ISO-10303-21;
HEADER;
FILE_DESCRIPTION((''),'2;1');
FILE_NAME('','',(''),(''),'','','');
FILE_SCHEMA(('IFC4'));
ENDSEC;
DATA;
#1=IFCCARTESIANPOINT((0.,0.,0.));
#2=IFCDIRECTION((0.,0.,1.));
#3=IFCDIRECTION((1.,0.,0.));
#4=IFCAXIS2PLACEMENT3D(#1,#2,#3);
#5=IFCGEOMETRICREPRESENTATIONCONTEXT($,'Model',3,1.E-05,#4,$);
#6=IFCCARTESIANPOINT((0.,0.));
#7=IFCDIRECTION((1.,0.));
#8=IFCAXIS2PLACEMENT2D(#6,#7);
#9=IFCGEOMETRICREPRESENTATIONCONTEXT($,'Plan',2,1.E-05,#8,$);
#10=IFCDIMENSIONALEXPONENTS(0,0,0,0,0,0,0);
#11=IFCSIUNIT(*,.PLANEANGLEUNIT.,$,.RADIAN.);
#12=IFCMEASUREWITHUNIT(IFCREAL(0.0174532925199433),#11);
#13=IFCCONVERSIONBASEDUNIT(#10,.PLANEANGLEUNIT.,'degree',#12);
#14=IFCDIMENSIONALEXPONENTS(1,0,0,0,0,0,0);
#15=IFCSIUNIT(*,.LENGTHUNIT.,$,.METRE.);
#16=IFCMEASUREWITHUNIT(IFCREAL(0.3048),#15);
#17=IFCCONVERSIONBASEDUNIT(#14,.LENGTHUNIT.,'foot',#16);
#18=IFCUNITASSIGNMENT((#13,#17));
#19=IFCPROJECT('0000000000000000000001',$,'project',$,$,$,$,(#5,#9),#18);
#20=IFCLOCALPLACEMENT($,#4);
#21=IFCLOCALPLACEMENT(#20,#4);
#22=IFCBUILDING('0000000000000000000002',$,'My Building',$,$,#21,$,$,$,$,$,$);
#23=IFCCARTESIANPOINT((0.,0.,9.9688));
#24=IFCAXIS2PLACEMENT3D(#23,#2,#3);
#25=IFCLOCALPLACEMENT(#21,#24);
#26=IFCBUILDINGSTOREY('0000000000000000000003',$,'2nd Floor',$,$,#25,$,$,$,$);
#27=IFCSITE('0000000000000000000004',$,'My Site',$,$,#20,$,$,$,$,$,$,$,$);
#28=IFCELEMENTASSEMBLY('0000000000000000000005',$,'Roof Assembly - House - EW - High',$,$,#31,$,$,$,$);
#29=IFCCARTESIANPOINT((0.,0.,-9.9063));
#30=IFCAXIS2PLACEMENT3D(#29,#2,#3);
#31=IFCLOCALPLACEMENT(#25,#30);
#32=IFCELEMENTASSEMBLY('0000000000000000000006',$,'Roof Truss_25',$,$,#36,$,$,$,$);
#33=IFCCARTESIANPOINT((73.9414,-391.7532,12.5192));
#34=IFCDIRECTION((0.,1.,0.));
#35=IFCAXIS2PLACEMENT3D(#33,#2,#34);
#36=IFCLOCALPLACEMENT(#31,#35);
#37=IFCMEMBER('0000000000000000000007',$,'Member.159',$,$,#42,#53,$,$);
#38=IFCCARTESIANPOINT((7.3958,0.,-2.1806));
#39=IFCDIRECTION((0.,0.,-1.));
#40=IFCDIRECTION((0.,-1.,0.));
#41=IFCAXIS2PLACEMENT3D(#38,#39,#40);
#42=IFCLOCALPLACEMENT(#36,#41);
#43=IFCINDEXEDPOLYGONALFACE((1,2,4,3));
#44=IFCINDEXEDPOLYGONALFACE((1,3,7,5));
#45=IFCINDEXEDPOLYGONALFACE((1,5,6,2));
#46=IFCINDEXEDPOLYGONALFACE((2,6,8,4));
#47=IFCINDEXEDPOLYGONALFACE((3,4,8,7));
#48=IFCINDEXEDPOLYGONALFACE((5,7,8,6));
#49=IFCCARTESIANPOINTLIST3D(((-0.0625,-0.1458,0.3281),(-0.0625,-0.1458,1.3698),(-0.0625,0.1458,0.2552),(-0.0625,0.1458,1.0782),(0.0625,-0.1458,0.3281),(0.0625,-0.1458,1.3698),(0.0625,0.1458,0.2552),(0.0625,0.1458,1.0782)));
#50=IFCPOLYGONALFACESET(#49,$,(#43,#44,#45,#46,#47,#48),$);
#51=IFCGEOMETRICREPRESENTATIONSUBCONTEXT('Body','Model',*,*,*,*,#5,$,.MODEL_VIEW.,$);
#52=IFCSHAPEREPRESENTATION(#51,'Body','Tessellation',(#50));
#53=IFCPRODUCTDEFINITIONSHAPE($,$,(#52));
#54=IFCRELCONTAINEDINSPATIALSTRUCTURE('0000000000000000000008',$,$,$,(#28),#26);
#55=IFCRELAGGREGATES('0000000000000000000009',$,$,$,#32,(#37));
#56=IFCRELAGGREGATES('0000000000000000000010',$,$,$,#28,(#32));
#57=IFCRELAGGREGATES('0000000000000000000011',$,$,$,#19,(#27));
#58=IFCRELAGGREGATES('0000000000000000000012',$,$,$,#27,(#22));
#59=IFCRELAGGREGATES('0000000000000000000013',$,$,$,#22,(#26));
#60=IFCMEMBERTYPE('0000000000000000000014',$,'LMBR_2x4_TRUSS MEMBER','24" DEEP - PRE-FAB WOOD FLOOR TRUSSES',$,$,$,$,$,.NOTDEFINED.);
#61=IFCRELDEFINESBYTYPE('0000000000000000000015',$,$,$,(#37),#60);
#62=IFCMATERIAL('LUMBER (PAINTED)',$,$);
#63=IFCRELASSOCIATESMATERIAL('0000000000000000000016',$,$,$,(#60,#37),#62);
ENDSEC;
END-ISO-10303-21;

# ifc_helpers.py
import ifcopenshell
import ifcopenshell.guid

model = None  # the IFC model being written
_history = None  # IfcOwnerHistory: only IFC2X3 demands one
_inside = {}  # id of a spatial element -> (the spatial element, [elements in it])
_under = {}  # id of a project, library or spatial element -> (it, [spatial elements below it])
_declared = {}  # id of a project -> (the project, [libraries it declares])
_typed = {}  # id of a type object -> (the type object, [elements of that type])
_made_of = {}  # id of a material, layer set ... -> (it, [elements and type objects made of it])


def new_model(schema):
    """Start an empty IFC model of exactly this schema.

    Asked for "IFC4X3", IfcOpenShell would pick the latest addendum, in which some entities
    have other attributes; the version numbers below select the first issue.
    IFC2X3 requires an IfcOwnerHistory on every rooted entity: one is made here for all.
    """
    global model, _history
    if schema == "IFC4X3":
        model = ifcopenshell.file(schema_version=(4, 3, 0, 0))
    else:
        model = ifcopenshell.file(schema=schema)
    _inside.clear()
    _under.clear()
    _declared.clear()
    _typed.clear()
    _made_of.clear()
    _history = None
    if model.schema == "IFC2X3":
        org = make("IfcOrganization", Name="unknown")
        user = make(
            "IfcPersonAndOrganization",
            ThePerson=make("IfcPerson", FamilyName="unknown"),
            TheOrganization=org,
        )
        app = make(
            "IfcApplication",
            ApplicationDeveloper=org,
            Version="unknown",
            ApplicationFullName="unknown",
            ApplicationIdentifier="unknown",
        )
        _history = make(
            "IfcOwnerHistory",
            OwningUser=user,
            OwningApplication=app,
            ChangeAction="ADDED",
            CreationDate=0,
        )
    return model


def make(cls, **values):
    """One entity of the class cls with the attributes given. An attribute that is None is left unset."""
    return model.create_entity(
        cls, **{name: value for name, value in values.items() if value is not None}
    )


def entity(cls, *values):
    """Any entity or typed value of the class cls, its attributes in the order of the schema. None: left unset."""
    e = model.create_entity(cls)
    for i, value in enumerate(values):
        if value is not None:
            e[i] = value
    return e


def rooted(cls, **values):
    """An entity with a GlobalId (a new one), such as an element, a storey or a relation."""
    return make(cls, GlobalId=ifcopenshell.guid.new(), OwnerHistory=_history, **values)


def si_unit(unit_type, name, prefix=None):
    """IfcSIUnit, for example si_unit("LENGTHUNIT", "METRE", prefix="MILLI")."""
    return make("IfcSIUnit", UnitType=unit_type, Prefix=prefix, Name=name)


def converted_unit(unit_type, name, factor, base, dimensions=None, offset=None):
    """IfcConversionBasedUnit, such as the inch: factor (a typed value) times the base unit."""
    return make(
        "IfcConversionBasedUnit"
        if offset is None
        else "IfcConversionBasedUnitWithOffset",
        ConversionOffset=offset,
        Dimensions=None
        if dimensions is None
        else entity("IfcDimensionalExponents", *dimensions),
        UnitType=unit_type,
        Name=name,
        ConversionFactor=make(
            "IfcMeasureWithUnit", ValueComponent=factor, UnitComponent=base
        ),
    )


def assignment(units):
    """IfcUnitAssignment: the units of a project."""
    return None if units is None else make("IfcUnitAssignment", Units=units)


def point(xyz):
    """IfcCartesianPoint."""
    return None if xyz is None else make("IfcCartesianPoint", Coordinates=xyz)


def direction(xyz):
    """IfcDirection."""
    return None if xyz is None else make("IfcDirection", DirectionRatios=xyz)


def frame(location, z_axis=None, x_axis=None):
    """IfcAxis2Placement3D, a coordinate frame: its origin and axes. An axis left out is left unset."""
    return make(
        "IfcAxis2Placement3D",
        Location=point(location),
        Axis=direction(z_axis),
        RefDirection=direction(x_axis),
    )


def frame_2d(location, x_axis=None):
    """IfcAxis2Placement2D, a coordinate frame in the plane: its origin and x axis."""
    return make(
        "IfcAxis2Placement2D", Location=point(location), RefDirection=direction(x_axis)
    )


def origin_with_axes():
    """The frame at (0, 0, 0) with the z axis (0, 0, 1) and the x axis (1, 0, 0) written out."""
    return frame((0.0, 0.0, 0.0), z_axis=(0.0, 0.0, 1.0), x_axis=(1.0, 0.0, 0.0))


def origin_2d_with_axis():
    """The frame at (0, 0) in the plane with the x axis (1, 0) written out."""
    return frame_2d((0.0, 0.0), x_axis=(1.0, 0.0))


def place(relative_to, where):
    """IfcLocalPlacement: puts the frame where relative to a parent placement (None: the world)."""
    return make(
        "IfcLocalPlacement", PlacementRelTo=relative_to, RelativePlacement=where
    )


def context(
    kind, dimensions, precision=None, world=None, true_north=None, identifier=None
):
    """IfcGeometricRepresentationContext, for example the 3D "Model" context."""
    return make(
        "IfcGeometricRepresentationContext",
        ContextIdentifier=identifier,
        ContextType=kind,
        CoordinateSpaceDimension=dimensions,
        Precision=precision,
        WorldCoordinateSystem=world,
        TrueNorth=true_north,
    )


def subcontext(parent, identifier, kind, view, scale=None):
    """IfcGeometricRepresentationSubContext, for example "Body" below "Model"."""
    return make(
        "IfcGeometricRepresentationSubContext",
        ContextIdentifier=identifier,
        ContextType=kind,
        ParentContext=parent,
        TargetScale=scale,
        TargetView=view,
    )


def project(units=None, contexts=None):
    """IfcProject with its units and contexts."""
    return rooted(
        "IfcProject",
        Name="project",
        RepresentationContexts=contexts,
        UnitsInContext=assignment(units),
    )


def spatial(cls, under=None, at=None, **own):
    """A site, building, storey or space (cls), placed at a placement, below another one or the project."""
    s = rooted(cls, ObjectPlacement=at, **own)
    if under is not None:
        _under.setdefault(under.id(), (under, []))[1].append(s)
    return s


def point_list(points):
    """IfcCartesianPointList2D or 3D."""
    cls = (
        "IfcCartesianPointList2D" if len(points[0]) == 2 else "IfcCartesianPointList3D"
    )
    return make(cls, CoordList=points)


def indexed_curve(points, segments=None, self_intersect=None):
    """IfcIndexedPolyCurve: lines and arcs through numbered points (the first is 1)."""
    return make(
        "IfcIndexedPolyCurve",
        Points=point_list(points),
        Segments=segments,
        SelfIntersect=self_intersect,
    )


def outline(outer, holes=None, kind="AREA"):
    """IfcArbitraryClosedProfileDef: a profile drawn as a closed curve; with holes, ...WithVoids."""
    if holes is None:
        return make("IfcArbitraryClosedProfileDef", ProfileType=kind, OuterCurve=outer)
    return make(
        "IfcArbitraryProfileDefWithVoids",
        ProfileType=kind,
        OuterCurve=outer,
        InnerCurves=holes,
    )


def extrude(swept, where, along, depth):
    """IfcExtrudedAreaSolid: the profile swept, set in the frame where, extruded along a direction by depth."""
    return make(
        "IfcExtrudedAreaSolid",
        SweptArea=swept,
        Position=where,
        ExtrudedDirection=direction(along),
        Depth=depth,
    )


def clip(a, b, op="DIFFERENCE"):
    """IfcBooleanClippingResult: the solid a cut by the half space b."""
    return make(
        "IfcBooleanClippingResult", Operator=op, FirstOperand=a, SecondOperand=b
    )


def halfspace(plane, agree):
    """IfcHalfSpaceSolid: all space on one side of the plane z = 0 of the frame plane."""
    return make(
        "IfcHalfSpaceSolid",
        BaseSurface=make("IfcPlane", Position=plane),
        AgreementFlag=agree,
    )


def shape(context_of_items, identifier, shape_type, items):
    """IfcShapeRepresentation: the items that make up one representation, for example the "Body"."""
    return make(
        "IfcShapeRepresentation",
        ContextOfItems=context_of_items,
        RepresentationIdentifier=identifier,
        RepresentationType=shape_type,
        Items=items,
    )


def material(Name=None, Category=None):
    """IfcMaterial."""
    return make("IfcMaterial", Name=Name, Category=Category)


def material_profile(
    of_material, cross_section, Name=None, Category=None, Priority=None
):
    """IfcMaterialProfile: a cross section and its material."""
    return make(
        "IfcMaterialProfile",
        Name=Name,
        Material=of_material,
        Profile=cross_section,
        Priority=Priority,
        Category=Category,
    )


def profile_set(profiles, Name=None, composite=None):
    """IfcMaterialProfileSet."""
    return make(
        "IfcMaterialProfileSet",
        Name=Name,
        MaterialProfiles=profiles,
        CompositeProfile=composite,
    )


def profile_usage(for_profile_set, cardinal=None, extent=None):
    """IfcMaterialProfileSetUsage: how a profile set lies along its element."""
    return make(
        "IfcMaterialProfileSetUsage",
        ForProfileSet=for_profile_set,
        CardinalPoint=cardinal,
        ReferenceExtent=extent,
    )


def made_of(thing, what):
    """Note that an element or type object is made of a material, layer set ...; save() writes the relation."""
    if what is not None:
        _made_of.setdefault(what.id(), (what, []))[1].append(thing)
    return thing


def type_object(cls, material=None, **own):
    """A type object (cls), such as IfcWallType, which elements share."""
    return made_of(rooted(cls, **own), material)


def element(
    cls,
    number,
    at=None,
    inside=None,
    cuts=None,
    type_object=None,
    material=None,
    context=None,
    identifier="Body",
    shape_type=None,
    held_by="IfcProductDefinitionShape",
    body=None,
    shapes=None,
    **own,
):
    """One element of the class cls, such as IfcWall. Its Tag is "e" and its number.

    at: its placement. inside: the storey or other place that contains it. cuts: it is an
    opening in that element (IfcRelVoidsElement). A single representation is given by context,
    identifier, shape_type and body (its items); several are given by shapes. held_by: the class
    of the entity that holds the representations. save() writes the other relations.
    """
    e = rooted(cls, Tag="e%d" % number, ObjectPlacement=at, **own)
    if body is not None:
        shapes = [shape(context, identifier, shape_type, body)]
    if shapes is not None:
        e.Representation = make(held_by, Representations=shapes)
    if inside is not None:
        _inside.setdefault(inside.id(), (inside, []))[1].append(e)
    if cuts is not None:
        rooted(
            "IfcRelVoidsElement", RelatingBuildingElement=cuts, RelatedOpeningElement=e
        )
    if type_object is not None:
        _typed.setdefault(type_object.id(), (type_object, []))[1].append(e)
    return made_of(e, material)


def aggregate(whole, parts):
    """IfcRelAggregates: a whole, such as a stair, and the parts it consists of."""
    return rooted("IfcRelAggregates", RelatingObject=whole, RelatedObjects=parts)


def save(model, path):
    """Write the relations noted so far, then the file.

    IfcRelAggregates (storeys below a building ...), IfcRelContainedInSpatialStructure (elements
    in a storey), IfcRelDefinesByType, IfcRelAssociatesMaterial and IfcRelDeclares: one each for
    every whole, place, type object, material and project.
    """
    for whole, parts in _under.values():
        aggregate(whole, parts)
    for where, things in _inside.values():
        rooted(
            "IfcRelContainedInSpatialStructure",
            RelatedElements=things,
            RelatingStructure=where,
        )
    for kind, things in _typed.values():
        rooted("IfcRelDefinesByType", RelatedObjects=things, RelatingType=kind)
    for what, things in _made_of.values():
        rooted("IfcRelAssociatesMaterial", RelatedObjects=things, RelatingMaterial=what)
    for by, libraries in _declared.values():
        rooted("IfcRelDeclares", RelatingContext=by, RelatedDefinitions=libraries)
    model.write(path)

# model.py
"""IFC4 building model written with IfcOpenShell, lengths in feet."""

from ifc_helpers import new_model, entity, si_unit, converted_unit, frame, origin_with_axes, origin_2d_with_axis, place, context, subcontext, project, spatial, indexed_curve, outline, extrude, clip, halfspace, material, material_profile, profile_set, profile_usage, type_object, element, aggregate, save


model = new_model("IFC4")

# Units and contexts
model_context = context("Model", 3, precision=1e-05, world=origin_with_axes())
plan_context = context("Plan", 2, precision=1e-05, world=origin_2d_with_axis())
body_context = subcontext(model_context, "Body", "Model", "MODEL_VIEW")
ifc_project = project(units=[converted_unit("PLANEANGLEUNIT", "degree", entity("IfcReal", 0.0174532925199433), si_unit("PLANEANGLEUNIT", "RADIAN"), dimensions=[0, 0, 0, 0, 0, 0, 0]), converted_unit("LENGTHUNIT", "foot", entity("IfcReal", 0.3048), si_unit("LENGTHUNIT", "METRE"), dimensions=[1, 0, 0, 0, 0, 0, 0])], contexts=[model_context, plan_context])

# Site, building, storey
site_placement = place(None, origin_with_axes())
site = spatial("IfcSite", under=ifc_project, at=site_placement, Name="My Site")
building_placement = place(site_placement, origin_with_axes())
building = spatial("IfcBuilding", under=site, at=building_placement, Name="My Building")
storey_placement = place(building_placement, frame((0.0, 0.0, 9.9688), z_axis=(0.0, 0.0, 1.0), x_axis=(1.0, 0.0, 0.0)))
storey = spatial("IfcBuildingStorey", under=building, at=storey_placement, Name="2nd Floor")

# Element assemblies, member
ifc_material_1 = material(Name="LUMBER (PAINTED)")
ifc_material_profile_1 = material_profile(ifc_material_1, outline(indexed_curve([(-0.0625, -0.1458), (0.0625, -0.1458), (0.0625, 0.1458), (-0.0625, 0.1458), (-0.0625, -0.1458)])))
ifc_profile_set_1 = profile_set([ifc_material_profile_1])
member_type_1 = type_object("IfcMemberType", Name="LMBR_2x4_TRUSS MEMBER", Description="24\" DEEP - PRE-FAB WOOD FLOOR TRUSSES", PredefinedType="NOTDEFINED", material=ifc_profile_set_1)
assembly_1_placement = place(storey_placement, frame((0.0, 0.0, -9.9063), z_axis=(0.0, 0.0, 1.0), x_axis=(1.0, 0.0, 0.0)))
assembly_1 = element("IfcElementAssembly", 1, at=assembly_1_placement, inside=storey, Name="Roof Assembly - House - EW - High")
assembly_2_placement = place(assembly_1_placement, frame((73.9414, -391.7532, 12.5192), z_axis=(0.0, 0.0, 1.0), x_axis=(0.0, 1.0, 0.0)))
assembly_2 = element("IfcElementAssembly", 2, at=assembly_2_placement, Name="Roof Truss_25")
ifc_profile_usage_1 = profile_usage(ifc_profile_set_1)
member_1_placement = place(assembly_2_placement, frame((7.3958, 0.0, -2.1806), z_axis=(0.0, 0.0, -1.0), x_axis=(0.0, -1.0, 0.0)))
member_1 = element("IfcMember", 3, at=member_1_placement, type_object=member_type_1, material=ifc_profile_usage_1, Name="Member.159", context=body_context, shape_type="Clipping", body=[
    clip(clip(extrude(outline(indexed_curve([(-0.0625, -0.1458), (0.0625, -0.1458), (0.0625, 0.1458), (-0.0625, 0.1458), (-0.0625, -0.1458)])), origin_with_axes(), (0.0, 0.0, 1.0), 1.3698), halfspace(frame((0.0, 7.5424, -1.5944), z_axis=(0.0, -0.242599, -0.970127), x_axis=(-1.0, 0.0, 0.0)), False)), halfspace(frame((-397.5032, -0.1458, 1.3698), z_axis=(0.0, 0.707099, 0.707114), x_axis=(1.0, 0.0, 0.0)), False)),
])
aggregate(assembly_2, [member_1])

aggregate(assembly_1, [assembly_2])

save(model, "model.ifc")
